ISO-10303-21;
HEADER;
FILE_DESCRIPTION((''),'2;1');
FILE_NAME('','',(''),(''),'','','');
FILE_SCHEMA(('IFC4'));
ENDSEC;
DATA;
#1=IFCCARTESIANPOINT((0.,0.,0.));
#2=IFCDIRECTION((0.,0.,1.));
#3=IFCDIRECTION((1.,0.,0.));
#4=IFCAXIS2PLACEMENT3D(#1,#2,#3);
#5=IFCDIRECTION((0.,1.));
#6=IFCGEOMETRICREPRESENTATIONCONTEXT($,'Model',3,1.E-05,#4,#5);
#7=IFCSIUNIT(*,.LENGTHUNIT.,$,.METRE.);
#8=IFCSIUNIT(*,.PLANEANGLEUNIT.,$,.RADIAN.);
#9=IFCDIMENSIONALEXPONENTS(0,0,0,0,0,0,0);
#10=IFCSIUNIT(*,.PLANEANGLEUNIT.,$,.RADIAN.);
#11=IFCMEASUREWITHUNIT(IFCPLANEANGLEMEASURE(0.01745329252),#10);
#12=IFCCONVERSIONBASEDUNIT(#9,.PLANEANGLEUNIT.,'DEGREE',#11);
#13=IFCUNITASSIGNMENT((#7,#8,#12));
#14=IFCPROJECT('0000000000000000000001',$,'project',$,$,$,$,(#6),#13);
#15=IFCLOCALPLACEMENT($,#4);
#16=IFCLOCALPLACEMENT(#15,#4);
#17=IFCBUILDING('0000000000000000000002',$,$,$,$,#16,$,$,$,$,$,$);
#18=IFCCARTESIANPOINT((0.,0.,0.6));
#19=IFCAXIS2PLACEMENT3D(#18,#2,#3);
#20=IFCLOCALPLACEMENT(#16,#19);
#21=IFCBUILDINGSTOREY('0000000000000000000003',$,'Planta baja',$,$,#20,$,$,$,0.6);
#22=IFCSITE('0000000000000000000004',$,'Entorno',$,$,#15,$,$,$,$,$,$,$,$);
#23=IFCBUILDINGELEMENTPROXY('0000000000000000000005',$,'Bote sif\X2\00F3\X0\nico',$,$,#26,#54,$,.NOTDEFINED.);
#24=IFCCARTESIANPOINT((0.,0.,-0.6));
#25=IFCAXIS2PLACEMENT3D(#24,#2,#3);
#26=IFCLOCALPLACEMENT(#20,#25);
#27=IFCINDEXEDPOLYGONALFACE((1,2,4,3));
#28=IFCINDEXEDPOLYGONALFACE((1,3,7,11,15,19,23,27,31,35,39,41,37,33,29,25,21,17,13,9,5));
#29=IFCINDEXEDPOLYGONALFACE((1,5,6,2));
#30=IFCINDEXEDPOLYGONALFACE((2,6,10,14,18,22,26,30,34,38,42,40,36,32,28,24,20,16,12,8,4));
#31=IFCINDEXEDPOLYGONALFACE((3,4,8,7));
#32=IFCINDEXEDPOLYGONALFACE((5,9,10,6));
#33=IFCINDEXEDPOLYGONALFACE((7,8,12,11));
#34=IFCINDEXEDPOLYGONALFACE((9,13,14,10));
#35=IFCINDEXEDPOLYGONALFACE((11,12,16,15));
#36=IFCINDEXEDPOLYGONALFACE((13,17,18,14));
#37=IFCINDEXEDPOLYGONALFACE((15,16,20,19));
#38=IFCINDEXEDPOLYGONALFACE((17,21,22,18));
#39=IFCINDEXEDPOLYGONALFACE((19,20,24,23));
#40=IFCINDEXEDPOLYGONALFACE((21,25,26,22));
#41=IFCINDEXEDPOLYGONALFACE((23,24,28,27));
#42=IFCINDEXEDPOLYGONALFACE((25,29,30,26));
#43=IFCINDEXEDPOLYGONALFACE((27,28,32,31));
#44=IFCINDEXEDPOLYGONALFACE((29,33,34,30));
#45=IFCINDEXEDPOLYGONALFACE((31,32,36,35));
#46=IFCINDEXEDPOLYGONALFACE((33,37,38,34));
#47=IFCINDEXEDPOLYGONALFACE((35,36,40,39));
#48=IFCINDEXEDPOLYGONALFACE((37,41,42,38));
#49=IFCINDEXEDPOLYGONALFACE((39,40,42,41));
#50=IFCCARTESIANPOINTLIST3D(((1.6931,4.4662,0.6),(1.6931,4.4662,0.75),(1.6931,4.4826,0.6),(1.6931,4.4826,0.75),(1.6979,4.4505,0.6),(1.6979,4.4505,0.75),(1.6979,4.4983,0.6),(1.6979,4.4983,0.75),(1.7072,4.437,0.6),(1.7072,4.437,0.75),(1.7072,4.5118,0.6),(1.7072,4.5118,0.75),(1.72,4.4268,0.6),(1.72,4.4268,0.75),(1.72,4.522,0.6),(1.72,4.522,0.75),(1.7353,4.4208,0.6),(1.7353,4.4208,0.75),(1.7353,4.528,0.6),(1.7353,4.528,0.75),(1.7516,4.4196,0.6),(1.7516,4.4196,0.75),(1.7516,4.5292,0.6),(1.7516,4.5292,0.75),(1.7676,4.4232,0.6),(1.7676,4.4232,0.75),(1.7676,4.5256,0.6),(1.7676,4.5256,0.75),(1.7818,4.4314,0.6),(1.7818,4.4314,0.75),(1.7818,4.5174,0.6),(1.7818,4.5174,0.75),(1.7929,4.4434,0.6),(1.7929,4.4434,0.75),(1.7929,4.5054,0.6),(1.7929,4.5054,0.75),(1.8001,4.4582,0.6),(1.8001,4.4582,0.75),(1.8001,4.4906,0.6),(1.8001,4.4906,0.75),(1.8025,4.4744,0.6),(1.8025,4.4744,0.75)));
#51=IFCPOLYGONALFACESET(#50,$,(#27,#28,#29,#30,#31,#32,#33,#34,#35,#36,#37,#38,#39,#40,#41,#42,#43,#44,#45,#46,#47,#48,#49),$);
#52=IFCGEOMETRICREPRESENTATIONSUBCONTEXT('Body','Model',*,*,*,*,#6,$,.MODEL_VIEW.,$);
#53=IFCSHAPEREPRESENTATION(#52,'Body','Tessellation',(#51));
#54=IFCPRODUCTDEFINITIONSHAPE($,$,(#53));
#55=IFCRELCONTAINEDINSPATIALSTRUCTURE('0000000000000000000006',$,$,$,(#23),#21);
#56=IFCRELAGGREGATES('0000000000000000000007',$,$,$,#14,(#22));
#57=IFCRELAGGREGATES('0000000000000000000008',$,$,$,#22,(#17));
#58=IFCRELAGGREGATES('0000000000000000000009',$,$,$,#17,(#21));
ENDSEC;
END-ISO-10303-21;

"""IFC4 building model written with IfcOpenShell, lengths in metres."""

from ifc_helpers import new_model, entity, si_unit, converted_unit, direction, frame, origin_with_axes, place, context, subcontext, project, spatial, element, save


model = new_model("IFC4")

# Units and contexts
model_context = context("Model", 3, precision=1e-05, world=origin_with_axes(), true_north=direction((0.0, 1.0)))
body_context = subcontext(model_context, "Body", "Model", "MODEL_VIEW")
ifc_project = project(units=[si_unit("LENGTHUNIT", "METRE"), si_unit("PLANEANGLEUNIT", "RADIAN"), converted_unit("PLANEANGLEUNIT", "DEGREE", entity("IfcPlaneAngleMeasure", 0.01745329252), si_unit("PLANEANGLEUNIT", "RADIAN"), dimensions=[0, 0, 0, 0, 0, 0, 0])], contexts=[model_context])

# Site, building, storey
site_placement = place(None, origin_with_axes())
site = spatial("IfcSite", under=ifc_project, at=site_placement, Name="Entorno")
building_placement = place(site_placement, origin_with_axes())
building = spatial("IfcBuilding", under=site, at=building_placement)
storey_placement = place(building_placement, frame((0.0, 0.0, 0.6), z_axis=(0.0, 0.0, 1.0), x_axis=(1.0, 0.0, 0.0)))
storey = spatial("IfcBuildingStorey", under=building, at=storey_placement, Name="Planta baja", Elevation=0.6)

# Building element proxy
proxy_1_placement = place(storey_placement, frame((0.0, 0.0, -0.6), z_axis=(0.0, 0.0, 1.0), x_axis=(1.0, 0.0, 0.0)))
ifc_direction_1 = entity("IfcDirection", [0.0, 0.0, 1.0])
element("IfcBuildingElementProxy", 1, at=proxy_1_placement, inside=storey, Name="Bote sifónico", PredefinedType="NOTDEFINED", context=body_context, shape_type="Brep", body=[
    entity("IfcExtrudedAreaSolidTapered", entity("IfcCircleProfileDef", "AREA", None, entity("IfcAxis2Placement2D", entity("IfcCartesianPoint", [0.0, 0.0]), entity("IfcDirection", [1.0, 0.0])), 0.055), entity("IfcAxis2Placement3D", entity("IfcCartesianPoint", [1.7475, 4.4744, 0.6]), ifc_direction_1, entity("IfcDirection", [1.0, 0.0, 0.0])), ifc_direction_1, 0.15, entity("IfcCircleProfileDef", "AREA", None, entity("IfcAxis2Placement2D", entity("IfcCartesianPoint", [0.0, 0.0]), entity("IfcDirection", [1.0, 0.0])), 0.055)),
])

save(model, "model.ifc")
